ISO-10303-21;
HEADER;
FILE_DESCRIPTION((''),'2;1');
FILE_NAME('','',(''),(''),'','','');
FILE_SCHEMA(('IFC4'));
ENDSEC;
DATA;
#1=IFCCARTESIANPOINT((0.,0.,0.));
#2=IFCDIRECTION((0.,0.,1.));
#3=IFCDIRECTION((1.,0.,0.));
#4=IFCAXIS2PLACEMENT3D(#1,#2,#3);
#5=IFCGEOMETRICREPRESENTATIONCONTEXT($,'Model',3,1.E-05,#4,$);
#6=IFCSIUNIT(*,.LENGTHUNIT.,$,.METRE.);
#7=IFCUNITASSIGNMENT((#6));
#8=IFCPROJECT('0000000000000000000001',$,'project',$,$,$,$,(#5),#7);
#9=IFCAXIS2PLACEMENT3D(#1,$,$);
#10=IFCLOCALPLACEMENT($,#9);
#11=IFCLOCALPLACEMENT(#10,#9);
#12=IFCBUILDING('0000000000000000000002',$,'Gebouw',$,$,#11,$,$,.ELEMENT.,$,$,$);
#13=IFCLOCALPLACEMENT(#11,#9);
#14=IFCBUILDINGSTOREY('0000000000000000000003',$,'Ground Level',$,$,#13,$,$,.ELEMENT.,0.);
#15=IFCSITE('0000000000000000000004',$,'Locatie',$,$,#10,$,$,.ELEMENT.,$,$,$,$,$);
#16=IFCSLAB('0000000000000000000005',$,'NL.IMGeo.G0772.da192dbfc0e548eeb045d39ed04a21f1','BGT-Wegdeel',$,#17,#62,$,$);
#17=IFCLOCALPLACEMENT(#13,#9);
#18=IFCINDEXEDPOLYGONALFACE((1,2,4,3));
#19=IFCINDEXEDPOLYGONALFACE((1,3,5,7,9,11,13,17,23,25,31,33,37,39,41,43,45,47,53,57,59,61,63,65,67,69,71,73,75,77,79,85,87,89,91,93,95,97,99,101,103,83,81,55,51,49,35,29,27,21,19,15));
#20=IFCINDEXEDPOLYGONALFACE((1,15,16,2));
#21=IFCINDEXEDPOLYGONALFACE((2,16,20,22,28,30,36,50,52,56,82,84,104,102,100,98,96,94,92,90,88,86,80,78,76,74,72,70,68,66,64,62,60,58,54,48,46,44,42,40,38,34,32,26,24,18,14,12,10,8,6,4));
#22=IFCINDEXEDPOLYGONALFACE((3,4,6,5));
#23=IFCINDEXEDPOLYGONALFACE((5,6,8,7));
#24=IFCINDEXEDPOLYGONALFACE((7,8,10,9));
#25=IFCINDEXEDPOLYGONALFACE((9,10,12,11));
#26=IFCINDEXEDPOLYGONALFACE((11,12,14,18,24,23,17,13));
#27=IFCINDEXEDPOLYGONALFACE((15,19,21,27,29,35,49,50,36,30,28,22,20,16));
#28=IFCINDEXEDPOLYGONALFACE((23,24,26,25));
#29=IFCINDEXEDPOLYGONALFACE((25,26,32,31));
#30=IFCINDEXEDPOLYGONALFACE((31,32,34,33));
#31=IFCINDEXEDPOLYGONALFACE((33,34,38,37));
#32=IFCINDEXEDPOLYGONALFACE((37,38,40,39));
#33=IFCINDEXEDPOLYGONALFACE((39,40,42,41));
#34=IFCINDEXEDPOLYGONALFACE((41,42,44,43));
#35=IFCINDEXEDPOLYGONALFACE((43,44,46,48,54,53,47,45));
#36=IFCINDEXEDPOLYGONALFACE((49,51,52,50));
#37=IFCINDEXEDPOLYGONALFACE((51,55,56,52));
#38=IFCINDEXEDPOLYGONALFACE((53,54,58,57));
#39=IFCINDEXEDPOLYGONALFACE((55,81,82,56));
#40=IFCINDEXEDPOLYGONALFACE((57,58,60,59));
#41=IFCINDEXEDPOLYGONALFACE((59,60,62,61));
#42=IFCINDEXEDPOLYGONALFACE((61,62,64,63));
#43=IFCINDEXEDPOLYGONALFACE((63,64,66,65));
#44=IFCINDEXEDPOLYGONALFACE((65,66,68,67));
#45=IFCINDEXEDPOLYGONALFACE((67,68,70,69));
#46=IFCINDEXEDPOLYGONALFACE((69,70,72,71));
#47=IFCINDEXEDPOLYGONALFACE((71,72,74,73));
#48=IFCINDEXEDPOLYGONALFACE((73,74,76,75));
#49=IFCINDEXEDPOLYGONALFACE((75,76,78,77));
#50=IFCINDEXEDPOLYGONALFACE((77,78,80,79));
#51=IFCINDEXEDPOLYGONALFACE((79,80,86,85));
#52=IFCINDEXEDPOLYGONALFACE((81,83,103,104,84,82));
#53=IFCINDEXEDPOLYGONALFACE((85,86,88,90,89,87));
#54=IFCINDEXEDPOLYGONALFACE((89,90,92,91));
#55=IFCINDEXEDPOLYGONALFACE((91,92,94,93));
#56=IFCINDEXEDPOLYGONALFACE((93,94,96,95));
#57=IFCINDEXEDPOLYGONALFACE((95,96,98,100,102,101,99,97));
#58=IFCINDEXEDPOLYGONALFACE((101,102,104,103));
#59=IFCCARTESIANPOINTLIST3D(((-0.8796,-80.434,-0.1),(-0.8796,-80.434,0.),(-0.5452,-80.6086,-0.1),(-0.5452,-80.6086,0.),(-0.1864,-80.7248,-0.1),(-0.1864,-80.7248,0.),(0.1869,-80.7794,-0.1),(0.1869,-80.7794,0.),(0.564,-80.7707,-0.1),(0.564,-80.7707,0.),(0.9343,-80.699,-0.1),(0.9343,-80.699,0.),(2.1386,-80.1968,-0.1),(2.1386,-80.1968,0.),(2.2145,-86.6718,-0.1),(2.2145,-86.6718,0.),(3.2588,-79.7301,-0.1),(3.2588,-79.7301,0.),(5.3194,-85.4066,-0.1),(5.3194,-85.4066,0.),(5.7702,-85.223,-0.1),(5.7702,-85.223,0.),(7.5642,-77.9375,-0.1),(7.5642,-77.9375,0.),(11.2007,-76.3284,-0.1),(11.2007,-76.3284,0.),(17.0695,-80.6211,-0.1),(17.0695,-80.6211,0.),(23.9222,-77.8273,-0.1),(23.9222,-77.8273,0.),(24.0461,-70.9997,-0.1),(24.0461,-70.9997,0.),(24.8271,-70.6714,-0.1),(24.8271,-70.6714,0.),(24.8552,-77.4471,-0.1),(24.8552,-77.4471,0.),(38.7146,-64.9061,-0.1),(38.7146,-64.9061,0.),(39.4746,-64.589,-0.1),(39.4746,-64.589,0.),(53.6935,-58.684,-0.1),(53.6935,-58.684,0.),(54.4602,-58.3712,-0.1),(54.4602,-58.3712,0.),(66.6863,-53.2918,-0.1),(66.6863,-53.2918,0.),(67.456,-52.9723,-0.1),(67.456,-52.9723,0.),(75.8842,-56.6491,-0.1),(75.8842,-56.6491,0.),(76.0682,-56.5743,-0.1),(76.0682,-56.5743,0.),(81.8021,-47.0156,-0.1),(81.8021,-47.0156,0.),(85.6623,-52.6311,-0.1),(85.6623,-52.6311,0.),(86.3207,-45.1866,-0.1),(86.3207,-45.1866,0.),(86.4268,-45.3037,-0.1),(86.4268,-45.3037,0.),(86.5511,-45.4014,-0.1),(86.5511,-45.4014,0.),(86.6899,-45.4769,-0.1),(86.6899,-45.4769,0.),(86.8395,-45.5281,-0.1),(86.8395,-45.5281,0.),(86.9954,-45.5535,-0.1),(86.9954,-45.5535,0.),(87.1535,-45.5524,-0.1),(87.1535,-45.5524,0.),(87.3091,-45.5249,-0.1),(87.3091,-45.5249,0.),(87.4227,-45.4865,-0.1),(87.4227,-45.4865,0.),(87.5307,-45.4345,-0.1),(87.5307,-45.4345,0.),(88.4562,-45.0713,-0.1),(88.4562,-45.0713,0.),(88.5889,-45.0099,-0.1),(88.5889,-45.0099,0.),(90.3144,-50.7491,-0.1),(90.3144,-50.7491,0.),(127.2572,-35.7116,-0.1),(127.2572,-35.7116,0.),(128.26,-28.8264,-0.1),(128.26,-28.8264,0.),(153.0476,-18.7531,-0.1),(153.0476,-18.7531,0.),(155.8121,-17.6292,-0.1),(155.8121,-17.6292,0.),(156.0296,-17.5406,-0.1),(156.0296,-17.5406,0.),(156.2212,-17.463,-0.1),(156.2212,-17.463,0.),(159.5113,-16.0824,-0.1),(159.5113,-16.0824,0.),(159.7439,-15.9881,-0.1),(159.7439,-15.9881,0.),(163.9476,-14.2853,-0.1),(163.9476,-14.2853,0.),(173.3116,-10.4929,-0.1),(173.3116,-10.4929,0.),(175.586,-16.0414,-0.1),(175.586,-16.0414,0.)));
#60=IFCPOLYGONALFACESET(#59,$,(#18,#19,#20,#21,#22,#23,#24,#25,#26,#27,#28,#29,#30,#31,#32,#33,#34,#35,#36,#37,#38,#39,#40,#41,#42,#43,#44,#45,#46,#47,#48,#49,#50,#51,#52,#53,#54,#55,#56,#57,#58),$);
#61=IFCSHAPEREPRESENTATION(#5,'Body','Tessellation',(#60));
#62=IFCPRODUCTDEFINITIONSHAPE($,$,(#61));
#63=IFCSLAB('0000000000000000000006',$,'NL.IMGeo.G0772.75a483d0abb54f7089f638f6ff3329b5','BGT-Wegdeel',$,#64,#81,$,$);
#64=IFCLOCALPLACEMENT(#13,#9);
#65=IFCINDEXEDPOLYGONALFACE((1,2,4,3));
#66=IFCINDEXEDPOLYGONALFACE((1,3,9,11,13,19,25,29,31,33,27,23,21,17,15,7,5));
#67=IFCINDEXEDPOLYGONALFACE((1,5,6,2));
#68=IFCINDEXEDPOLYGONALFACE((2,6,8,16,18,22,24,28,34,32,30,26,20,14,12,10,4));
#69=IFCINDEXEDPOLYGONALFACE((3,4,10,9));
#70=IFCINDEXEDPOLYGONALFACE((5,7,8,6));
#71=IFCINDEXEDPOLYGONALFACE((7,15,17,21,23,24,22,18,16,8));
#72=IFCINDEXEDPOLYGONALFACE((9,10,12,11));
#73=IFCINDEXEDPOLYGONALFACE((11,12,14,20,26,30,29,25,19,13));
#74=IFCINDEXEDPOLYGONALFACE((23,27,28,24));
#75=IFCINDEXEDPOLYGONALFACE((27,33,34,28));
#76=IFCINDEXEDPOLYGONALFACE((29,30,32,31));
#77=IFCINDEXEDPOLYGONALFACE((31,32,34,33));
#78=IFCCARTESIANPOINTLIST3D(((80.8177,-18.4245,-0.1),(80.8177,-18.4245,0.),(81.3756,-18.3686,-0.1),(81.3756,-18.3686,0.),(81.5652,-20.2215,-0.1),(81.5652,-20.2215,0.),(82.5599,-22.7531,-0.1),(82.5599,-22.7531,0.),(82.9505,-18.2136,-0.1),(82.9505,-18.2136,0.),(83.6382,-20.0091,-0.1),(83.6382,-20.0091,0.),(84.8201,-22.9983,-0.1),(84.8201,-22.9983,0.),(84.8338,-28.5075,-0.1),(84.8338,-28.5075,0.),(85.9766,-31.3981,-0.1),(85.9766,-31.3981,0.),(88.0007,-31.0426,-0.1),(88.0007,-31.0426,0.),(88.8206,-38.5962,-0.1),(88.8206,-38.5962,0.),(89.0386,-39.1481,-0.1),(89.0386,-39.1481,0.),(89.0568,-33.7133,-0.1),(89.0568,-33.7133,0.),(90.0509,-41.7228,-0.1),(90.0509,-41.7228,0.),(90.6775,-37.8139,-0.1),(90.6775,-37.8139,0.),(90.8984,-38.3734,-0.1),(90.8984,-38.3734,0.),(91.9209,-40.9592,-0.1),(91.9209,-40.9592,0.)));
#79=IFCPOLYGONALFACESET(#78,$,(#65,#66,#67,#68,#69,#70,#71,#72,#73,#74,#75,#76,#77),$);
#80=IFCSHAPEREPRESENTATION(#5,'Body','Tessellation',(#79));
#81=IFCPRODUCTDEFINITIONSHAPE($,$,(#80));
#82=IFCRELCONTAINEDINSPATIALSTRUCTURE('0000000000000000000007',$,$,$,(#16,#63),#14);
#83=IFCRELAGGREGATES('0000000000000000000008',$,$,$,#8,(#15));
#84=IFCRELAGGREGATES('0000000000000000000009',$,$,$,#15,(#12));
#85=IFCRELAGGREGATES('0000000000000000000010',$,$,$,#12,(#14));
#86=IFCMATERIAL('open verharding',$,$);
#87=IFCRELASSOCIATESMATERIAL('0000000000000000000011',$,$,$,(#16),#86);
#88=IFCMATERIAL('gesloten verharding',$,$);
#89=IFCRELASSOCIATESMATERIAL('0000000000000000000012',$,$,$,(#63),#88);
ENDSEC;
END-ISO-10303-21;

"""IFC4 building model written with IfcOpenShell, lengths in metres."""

from ifc_helpers import new_model, si_unit, frame, origin, origin_with_axes, place, context, project, spatial, polyline, outline, extrude, material, element, save


model = new_model("IFC4")

# Units and contexts
model_context = context("Model", 3, precision=1e-05, world=origin_with_axes())
ifc_project = project(units=[si_unit("LENGTHUNIT", "METRE")], contexts=[model_context])

# Site, building, storey
site_placement = place(None, origin())
site = spatial("IfcSite", under=ifc_project, at=site_placement, Name="Locatie", CompositionType="ELEMENT")
building_placement = place(site_placement, origin())
building = spatial("IfcBuilding", under=site, at=building_placement, Name="Gebouw", CompositionType="ELEMENT")
storey_placement = place(building_placement, origin())
storey = spatial("IfcBuildingStorey", under=building, at=storey_placement, Name="Ground Level", CompositionType="ELEMENT", Elevation=0.0)

# Slabs
ifc_material_1 = material(Name="open verharding")
ifc_material_2 = material(Name="gesloten verharding")
slab_1_placement = place(storey_placement, origin())
element("IfcSlab", 1, at=slab_1_placement, inside=storey, material=ifc_material_1, Name="NL.IMGeo.G0772.da192dbfc0e548eeb045d39ed04a21f1", Description="BGT-Wegdeel", context=model_context, shape_type="SweptSolid", body=[
    extrude(outline(polyline([(128.26, -28.8264), (153.0476, -18.7531), (155.8121, -17.6292), (156.0296, -17.5406), (156.2212, -17.463), (159.5113, -16.0824), (159.7439, -15.9881), (163.9476, -14.2853), (173.3116, -10.4929), (175.586, -16.0414), (127.2572, -35.7116), (90.3144, -50.7491), (85.6623, -52.6311), (76.0682, -56.5743), (75.8842, -56.6491), (24.8552, -77.4471), (23.9222, -77.8273), (17.0695, -80.6211), (5.7702, -85.223), (5.3194, -85.4066), (2.2145, -86.6718), (-0.8796, -80.434), (-0.5452, -80.6086), (-0.1864, -80.7248), (0.1869, -80.7794), (0.564, -80.7707), (0.9343, -80.699), (2.1386, -80.1968), (3.2588, -79.7301), (7.5642, -77.9375), (11.2007, -76.3284), (24.0461, -70.9997), (24.8271, -70.6714), (38.7146, -64.9061), (39.4746, -64.589), (53.6935, -58.684), (54.4602, -58.3712), (66.6863, -53.2918), (67.456, -52.9723), (81.8021, -47.0156), (86.3207, -45.1866), (86.4268, -45.3037), (86.5511, -45.4014), (86.6899, -45.4769), (86.8395, -45.5281), (86.9954, -45.5535), (87.1535, -45.5524), (87.3091, -45.5249), (87.4227, -45.4865), (87.5307, -45.4345), (88.4562, -45.0713), (88.5889, -45.0099), (128.26, -28.8264)])), frame((0.0, 0.0, -0.1), z_axis=(0.0, 0.0, 1.0), x_axis=(1.0, 0.0, 0.0)), (0.0, 0.0, 1.0), 0.1),
])
slab_2_placement = place(storey_placement, origin())
element("IfcSlab", 2, at=slab_2_placement, inside=storey, material=ifc_material_2, Name="NL.IMGeo.G0772.75a483d0abb54f7089f638f6ff3329b5", Description="BGT-Wegdeel", context=model_context, shape_type="SweptSolid", body=[
    extrude(outline(polyline([(88.0007, -31.0426), (89.0568, -33.7133), (90.6775, -37.8139), (90.8984, -38.3734), (91.9209, -40.9592), (90.0509, -41.7228), (89.0386, -39.1481), (88.8206, -38.5962), (85.9766, -31.3981), (84.8338, -28.5075), (82.5599, -22.7531), (81.5652, -20.2215), (80.8177, -18.4245), (81.3756, -18.3686), (82.9505, -18.2136), (83.6382, -20.0091), (84.8201, -22.9983), (88.0007, -31.0426)])), frame((0.0, 0.0, -0.1), z_axis=(0.0, 0.0, 1.0), x_axis=(1.0, 0.0, 0.0)), (0.0, 0.0, 1.0), 0.1),
])

save(model, "model.ifc")
